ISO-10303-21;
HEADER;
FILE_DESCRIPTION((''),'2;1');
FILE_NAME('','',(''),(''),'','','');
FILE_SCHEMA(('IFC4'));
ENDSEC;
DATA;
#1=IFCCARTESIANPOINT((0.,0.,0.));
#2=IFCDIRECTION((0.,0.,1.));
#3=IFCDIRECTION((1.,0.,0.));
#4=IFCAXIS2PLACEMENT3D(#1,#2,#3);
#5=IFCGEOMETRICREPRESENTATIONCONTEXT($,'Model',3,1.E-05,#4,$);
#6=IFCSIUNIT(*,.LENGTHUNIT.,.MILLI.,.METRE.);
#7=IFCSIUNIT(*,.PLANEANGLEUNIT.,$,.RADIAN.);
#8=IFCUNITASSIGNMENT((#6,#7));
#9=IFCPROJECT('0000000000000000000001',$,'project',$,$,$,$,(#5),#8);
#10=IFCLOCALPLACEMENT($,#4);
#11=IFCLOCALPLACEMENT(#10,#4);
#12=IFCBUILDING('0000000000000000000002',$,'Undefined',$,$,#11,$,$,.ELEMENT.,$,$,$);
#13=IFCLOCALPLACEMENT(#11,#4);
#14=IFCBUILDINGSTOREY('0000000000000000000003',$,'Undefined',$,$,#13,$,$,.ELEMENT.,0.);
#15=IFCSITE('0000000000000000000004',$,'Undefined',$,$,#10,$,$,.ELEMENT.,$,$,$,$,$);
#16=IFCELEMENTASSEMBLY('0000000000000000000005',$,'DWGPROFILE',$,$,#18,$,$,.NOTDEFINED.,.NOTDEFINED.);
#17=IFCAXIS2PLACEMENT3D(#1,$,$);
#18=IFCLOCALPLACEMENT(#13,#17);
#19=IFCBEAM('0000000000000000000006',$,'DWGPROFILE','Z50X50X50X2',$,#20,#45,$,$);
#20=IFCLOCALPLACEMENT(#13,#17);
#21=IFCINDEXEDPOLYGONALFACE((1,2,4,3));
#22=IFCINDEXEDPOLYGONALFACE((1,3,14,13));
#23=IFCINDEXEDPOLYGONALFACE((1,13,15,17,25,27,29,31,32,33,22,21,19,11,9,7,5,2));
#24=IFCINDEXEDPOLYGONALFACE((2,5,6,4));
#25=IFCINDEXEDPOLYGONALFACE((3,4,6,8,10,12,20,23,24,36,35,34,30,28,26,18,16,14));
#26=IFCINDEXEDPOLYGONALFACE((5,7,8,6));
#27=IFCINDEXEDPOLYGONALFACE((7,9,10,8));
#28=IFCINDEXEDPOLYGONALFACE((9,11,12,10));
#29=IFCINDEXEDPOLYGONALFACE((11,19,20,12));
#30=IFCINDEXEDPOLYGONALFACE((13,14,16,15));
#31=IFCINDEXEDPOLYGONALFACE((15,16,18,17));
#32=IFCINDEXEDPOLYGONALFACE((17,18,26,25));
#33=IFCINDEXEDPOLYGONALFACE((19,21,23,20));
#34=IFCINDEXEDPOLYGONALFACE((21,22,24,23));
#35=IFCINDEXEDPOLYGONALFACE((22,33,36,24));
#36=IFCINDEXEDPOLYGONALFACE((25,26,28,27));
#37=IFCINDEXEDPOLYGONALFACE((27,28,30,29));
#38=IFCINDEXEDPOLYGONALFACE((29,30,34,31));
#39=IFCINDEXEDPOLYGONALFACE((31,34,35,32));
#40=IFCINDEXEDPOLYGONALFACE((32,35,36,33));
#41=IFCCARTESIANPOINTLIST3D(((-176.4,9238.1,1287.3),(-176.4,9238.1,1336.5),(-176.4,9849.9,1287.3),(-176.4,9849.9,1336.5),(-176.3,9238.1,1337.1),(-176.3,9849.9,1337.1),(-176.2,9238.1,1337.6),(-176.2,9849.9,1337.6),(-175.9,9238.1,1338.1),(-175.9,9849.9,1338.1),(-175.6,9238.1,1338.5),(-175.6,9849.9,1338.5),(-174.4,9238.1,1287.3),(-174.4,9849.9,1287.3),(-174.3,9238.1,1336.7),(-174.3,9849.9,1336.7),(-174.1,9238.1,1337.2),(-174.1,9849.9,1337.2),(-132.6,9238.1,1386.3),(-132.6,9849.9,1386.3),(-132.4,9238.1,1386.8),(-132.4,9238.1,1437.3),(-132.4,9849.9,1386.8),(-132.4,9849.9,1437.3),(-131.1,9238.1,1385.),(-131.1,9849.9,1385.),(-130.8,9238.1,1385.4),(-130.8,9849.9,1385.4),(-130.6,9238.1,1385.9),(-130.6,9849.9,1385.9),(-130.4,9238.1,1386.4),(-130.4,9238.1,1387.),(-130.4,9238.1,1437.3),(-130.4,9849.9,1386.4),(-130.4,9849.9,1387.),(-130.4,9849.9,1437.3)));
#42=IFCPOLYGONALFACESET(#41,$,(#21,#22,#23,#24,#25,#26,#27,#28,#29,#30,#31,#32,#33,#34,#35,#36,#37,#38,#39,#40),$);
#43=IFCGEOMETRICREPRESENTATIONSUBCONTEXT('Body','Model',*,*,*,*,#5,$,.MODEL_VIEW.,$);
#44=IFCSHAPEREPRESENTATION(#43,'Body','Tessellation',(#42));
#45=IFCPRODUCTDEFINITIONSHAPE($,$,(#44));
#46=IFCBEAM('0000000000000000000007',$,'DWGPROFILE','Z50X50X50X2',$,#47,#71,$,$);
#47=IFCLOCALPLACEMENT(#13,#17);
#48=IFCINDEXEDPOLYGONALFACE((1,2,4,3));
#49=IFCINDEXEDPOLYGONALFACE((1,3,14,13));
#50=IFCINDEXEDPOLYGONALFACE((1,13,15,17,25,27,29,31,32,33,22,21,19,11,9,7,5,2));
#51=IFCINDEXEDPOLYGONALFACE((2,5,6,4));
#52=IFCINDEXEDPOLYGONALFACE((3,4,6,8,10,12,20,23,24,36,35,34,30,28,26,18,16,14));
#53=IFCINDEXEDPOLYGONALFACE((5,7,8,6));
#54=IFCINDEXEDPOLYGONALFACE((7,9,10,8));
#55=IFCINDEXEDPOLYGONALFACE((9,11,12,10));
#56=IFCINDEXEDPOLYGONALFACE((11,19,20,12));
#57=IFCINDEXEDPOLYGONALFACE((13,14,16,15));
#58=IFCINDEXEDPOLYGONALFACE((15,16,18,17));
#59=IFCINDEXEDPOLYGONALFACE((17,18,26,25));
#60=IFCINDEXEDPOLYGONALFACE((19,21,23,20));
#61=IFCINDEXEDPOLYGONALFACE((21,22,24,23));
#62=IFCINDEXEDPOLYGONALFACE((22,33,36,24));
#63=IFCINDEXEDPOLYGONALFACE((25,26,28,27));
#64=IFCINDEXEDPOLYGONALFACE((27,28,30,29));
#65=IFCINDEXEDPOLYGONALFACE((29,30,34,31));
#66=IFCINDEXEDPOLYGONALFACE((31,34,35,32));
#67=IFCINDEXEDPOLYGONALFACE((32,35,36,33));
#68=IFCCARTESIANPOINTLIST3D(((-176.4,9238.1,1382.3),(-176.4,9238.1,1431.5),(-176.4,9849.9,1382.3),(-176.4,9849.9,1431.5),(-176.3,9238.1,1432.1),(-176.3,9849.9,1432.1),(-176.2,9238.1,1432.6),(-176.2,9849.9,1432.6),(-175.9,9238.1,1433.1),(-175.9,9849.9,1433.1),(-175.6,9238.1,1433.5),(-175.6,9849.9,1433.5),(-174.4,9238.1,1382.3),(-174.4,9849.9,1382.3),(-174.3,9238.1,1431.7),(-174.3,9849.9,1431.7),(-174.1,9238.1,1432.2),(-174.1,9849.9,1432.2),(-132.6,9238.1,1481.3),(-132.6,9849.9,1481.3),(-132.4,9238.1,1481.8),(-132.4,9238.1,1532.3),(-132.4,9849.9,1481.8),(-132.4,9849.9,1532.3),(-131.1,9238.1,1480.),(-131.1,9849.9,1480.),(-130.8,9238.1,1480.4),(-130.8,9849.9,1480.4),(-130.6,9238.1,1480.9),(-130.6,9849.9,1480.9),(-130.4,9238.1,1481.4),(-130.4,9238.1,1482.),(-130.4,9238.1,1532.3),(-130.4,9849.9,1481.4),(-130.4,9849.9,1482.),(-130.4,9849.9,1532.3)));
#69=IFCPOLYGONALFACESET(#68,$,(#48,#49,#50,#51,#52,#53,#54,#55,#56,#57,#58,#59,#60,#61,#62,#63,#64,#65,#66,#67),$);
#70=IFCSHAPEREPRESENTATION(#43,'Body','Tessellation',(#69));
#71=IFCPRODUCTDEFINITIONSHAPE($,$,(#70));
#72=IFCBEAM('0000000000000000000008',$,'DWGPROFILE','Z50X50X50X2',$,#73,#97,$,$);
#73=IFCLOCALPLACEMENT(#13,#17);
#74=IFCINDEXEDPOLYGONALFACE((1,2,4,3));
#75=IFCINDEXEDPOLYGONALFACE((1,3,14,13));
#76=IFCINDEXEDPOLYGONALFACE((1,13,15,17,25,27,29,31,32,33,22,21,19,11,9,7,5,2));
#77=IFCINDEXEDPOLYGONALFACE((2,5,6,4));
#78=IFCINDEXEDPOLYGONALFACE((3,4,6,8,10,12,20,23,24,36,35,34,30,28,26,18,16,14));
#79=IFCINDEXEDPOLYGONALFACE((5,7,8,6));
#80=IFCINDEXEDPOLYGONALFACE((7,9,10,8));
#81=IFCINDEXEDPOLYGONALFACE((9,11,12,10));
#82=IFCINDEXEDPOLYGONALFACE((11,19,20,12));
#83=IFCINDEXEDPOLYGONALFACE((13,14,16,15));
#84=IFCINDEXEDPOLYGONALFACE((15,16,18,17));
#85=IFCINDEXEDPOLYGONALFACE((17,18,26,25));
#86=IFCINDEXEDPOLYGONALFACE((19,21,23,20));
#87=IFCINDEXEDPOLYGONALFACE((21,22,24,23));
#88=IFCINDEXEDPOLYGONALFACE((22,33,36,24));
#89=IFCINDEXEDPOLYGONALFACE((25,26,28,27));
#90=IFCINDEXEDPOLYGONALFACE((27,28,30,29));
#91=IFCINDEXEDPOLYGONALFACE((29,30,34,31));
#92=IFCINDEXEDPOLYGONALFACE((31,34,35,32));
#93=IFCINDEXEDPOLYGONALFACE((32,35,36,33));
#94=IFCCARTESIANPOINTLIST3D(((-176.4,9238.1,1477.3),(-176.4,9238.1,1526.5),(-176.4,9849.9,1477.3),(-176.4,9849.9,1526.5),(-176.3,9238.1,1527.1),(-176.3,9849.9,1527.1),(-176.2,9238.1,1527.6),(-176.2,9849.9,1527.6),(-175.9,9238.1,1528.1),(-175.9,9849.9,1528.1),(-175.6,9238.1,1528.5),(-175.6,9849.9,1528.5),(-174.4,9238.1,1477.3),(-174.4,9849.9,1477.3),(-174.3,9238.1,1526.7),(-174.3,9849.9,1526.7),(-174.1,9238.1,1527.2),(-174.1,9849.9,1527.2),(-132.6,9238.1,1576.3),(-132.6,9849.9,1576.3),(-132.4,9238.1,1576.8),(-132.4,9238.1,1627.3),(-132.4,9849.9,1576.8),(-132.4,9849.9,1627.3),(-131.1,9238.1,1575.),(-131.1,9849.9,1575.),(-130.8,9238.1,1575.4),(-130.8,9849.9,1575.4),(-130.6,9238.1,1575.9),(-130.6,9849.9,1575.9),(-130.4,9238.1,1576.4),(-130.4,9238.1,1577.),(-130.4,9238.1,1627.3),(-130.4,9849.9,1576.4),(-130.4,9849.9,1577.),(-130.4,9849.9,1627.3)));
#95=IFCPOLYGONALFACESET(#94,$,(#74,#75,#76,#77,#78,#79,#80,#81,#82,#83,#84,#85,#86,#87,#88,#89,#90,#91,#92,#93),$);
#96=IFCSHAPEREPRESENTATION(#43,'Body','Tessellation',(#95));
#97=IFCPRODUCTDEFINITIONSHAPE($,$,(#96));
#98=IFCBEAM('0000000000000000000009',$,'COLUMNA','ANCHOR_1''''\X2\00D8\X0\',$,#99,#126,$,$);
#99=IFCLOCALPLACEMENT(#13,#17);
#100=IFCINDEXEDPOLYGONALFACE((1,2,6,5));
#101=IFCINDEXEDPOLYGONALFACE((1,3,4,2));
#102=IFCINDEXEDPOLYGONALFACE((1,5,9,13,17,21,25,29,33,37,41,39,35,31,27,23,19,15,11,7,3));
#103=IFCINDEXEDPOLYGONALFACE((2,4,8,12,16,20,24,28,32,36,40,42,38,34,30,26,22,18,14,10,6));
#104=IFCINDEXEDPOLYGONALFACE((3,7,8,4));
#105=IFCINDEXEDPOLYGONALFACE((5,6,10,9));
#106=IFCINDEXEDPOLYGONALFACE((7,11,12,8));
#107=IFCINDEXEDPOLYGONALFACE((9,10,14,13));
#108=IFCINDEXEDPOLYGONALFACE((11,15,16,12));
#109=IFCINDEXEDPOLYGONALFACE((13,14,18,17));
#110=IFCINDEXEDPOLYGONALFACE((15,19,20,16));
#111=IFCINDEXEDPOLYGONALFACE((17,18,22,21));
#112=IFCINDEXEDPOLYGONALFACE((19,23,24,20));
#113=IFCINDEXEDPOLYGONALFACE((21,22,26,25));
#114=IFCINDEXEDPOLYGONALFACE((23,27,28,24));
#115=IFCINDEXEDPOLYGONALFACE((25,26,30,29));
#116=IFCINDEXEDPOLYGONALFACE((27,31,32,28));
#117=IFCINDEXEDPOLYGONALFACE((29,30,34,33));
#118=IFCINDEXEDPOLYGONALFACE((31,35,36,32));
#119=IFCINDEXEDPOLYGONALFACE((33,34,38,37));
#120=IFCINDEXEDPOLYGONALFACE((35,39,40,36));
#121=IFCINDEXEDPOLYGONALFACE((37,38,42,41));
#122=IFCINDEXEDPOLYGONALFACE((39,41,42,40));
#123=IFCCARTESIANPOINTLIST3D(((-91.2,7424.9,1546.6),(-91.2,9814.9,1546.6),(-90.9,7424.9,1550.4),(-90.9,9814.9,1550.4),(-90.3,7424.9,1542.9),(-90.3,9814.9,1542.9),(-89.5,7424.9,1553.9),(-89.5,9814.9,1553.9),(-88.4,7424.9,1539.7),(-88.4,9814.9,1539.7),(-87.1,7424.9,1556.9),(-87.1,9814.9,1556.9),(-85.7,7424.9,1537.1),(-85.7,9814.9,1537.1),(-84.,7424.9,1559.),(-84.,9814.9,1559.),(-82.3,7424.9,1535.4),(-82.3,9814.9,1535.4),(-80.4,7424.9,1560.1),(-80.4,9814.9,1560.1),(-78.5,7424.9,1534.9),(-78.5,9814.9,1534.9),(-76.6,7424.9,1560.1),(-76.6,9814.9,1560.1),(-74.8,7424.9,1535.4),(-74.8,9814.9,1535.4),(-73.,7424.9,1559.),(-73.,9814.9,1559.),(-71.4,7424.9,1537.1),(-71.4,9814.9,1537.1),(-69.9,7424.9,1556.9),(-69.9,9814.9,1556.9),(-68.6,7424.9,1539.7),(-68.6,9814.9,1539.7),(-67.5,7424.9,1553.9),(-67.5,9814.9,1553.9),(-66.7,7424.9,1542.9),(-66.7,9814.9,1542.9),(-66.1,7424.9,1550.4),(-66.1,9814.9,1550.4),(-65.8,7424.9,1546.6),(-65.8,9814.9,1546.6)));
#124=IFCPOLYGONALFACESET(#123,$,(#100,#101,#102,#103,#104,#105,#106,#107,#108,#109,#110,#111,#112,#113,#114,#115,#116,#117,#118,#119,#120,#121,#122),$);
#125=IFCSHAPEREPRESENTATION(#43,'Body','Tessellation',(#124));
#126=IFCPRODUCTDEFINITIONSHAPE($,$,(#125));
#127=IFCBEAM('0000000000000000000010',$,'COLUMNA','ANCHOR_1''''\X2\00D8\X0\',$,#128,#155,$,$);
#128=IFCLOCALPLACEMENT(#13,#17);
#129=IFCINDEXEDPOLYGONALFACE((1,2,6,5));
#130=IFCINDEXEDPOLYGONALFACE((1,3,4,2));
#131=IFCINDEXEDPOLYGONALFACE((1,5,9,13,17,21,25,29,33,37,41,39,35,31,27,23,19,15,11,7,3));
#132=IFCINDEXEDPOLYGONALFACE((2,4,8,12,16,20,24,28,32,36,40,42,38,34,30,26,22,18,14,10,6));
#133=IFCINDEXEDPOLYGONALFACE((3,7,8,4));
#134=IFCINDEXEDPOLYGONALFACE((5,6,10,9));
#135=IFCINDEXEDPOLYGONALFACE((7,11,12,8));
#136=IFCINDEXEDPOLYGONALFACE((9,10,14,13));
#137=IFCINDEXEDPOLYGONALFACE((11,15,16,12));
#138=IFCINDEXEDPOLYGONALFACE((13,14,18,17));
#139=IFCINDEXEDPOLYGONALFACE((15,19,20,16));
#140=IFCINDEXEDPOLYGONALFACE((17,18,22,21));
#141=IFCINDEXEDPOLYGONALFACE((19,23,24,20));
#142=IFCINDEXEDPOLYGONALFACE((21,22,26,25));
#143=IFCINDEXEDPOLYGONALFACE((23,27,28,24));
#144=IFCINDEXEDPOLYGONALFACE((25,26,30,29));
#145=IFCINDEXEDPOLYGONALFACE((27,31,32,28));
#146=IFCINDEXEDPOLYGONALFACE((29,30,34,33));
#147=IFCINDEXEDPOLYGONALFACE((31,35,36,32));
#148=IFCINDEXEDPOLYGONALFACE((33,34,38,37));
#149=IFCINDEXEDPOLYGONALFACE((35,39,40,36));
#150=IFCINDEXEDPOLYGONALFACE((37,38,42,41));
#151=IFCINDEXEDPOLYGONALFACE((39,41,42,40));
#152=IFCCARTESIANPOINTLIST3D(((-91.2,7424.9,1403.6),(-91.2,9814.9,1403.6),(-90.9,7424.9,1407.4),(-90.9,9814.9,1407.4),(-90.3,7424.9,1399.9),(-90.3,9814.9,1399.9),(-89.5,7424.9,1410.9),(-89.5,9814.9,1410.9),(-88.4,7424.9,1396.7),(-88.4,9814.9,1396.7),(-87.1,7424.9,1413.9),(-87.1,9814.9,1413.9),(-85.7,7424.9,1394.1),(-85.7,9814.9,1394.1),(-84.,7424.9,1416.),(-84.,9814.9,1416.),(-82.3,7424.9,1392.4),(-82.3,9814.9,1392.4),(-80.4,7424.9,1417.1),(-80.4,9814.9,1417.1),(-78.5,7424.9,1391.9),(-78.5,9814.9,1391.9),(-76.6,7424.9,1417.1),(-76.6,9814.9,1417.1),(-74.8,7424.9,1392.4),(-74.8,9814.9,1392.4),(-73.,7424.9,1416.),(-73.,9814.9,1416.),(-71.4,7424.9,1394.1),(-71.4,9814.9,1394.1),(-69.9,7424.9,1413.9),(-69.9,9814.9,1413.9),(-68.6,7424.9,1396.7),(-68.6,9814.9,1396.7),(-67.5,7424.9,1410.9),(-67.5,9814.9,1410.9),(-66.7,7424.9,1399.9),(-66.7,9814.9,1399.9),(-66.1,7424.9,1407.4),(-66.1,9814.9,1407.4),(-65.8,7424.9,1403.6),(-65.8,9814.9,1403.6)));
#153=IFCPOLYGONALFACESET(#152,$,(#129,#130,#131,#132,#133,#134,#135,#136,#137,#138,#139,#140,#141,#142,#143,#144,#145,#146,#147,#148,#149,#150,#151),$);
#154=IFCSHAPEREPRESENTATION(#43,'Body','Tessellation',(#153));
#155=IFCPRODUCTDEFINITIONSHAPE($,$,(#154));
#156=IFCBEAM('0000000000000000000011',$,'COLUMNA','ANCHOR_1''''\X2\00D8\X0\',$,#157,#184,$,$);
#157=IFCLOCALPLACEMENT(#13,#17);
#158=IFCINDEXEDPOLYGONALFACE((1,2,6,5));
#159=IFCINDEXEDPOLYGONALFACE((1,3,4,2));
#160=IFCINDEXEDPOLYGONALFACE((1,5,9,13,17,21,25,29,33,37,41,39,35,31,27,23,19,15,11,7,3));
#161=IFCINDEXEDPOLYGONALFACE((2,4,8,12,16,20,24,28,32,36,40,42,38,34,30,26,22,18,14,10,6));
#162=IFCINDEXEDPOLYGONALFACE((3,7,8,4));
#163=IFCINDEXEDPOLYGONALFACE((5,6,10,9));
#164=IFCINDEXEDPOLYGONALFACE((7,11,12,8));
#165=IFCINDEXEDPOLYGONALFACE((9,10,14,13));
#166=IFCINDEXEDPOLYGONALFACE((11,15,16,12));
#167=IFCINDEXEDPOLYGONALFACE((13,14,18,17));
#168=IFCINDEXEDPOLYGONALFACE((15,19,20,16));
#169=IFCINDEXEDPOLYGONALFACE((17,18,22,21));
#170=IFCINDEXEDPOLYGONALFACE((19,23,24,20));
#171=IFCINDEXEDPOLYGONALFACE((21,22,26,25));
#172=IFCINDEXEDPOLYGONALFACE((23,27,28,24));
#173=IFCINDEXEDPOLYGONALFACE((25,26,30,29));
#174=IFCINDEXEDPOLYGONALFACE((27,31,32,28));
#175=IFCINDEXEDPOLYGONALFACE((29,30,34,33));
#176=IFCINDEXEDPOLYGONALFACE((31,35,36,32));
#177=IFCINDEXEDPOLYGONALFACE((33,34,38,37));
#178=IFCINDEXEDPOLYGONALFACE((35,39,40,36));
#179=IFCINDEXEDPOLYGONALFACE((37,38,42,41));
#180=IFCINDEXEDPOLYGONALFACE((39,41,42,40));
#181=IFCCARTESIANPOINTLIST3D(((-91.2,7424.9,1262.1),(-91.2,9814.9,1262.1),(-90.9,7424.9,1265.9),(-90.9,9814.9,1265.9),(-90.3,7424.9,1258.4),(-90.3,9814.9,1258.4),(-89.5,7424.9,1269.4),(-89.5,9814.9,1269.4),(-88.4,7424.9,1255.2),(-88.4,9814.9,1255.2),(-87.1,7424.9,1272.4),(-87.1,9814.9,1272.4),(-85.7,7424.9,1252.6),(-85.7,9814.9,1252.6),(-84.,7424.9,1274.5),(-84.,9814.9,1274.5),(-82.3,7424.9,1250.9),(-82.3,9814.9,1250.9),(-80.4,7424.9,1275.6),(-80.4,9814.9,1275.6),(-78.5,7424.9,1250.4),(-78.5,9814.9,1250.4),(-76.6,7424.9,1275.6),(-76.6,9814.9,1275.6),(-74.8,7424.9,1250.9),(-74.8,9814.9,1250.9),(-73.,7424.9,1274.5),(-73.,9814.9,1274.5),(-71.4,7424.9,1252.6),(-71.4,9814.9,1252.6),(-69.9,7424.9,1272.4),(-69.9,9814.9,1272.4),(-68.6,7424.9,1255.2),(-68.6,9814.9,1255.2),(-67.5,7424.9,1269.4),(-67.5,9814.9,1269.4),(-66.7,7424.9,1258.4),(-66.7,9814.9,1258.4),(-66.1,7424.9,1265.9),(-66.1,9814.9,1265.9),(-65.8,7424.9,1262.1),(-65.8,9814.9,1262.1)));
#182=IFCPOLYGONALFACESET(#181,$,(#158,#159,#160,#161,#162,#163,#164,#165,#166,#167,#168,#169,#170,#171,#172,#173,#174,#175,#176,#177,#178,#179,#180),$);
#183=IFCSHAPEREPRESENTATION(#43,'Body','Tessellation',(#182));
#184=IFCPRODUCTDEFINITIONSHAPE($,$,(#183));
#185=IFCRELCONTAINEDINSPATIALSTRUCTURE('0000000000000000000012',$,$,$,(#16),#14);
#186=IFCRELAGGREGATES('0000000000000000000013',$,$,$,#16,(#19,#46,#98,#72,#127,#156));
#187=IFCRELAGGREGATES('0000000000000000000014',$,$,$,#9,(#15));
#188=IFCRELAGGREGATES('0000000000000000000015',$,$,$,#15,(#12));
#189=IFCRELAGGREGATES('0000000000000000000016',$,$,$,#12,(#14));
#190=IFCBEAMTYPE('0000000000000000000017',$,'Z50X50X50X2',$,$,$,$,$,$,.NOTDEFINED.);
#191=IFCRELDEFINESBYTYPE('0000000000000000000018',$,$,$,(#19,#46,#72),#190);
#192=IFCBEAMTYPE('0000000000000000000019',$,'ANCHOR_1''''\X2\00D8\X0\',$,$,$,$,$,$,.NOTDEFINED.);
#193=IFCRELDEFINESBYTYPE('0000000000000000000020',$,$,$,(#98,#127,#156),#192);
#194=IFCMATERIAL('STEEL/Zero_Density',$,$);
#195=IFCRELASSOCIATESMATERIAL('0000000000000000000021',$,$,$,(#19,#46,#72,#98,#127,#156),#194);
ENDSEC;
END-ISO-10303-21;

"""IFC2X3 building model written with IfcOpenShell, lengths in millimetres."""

from ifc_helpers import new_model, si_unit, frame, origin_with_axes, origin_2d_with_axis, place, context, subcontext, project, spatial, polyline, circle, outline, extrude, material, type_object, element, aggregate, save


model = new_model("IFC2X3")

# Units and contexts
model_context = context("Model", 3, precision=1e-05, world=origin_with_axes())
body_context = subcontext(model_context, "Body", "Model", "MODEL_VIEW")
ifc_project = project(units=[si_unit("LENGTHUNIT", "METRE", prefix="MILLI"), si_unit("PLANEANGLEUNIT", "RADIAN")], contexts=[model_context])

# Site, building, storey
site_placement = place(None, origin_with_axes())
site = spatial("IfcSite", under=ifc_project, at=site_placement, Name="Undefined", CompositionType="ELEMENT")
building_placement = place(site_placement, origin_with_axes())
building = spatial("IfcBuilding", under=site, at=building_placement, Name="Undefined", CompositionType="ELEMENT")
storey_placement = place(building_placement, origin_with_axes())
storey = spatial("IfcBuildingStorey", under=building, at=storey_placement, Name="Undefined", CompositionType="ELEMENT", Elevation=0.0)

# Shared definitions
ifc_material_1 = material(Name="STEEL/Zero_Density")
beam_type_1 = type_object("IfcBeamType", Name="Z50X50X50X2", PredefinedType="NOTDEFINED")

# Element assembly, beams
assembly_1_placement = place(storey_placement, origin_with_axes())
assembly_1 = element("IfcElementAssembly", 1, at=assembly_1_placement, inside=storey, Name="DWGPROFILE", AssemblyPlace="NOTDEFINED", PredefinedType="NOTDEFINED")
beam_1_placement = place(assembly_1_placement, frame((-153.4, 9849.9, 1362.3), z_axis=(0.0, 0.0, 1.0), x_axis=(0.0, -1.0, 0.0)))
beam_1 = element("IfcBeam", 2, at=beam_1_placement, type_object=beam_type_1, material=ifc_material_1, Name="DWGPROFILE", Description="Z50X50X50X2", context=body_context, shape_type="SweptSolid", body=[
    extrude(outline(polyline([(-22.9, 24.1), (-23.0, 24.7), (-23.0, 75.0), (-21.0, 75.0), (-21.0, 24.5), (-20.7, 24.0), (22.2, -23.8), (22.6, -24.2), (22.8, -24.7), (22.9, -25.2), (23.0, -25.8), (23.0, -75.0), (21.0, -75.0), (21.0, -25.6), (20.7, -25.1), (-22.2, 22.6), (-22.6, 23.1), (-22.8, 23.6), (-22.9, 24.1)])), frame((611.8, 0.0, 0.0), z_axis=(-1.0, 0.0, 0.0), x_axis=(0.0, -1.0, 0.0)), (0.0, 0.0, 1.0), 611.8),
])
beam_2_placement = place(assembly_1_placement, frame((-153.4, 9849.9, 1457.3), z_axis=(0.0, 0.0, 1.0), x_axis=(0.0, -1.0, 0.0)))
beam_2 = element("IfcBeam", 3, at=beam_2_placement, type_object=beam_type_1, material=ifc_material_1, Name="DWGPROFILE", Description="Z50X50X50X2", context=body_context, shape_type="SweptSolid", body=[
    extrude(outline(polyline([(-22.9, 24.1), (-23.0, 24.7), (-23.0, 75.0), (-21.0, 75.0), (-21.0, 24.5), (-20.7, 24.0), (22.2, -23.8), (22.6, -24.2), (22.8, -24.7), (22.9, -25.2), (23.0, -25.8), (23.0, -75.0), (21.0, -75.0), (21.0, -25.6), (20.7, -25.1), (-22.2, 22.6), (-22.6, 23.1), (-22.8, 23.6), (-22.9, 24.1)])), frame((611.8, 0.0, 0.0), z_axis=(-1.0, 0.0, 0.0), x_axis=(0.0, -1.0, 0.0)), (0.0, 0.0, 1.0), 611.8),
])
beam_3_placement = place(assembly_1_placement, frame((-153.4, 9849.9, 1552.3), z_axis=(0.0, 0.0, 1.0), x_axis=(0.0, -1.0, 0.0)))
beam_3 = element("IfcBeam", 4, at=beam_3_placement, type_object=beam_type_1, material=ifc_material_1, Name="DWGPROFILE", Description="Z50X50X50X2", context=body_context, shape_type="SweptSolid", body=[
    extrude(outline(polyline([(-22.9, 24.1), (-23.0, 24.7), (-23.0, 75.0), (-21.0, 75.0), (-21.0, 24.5), (-20.7, 24.0), (22.2, -23.8), (22.6, -24.2), (22.8, -24.7), (22.9, -25.2), (23.0, -25.8), (23.0, -75.0), (21.0, -75.0), (21.0, -25.6), (20.7, -25.1), (-22.2, 22.6), (-22.6, 23.1), (-22.8, 23.6), (-22.9, 24.1)])), frame((611.8, 0.0, 0.0), z_axis=(-1.0, 0.0, 0.0), x_axis=(0.0, -1.0, 0.0)), (0.0, 0.0, 1.0), 611.8),
])
beam_type_2 = type_object("IfcBeamType", Name="ANCHOR_1''Ø", PredefinedType="NOTDEFINED")
beam_4_placement = place(assembly_1_placement, frame((-78.5, 9814.9, 1547.6), z_axis=(-1.0, 0.0, 0.0), x_axis=(0.0, -1.0, 0.0)))
beam_4 = element("IfcBeam", 5, at=beam_4_placement, type_object=beam_type_2, material=ifc_material_1, Name="COLUMNA", Description="ANCHOR_1''Ø", context=body_context, shape_type="SweptSolid", body=[
    extrude(circle(Radius=12.7, at=origin_2d_with_axis()), frame((2390.0, 0.0, 0.0), z_axis=(-1.0, 0.0, 0.0), x_axis=(0.0, -1.0, 0.0)), (0.0, 0.0, 1.0), 2390.0),
])
beam_5_placement = place(assembly_1_placement, frame((-78.5, 9814.9, 1404.6), z_axis=(-1.0, 0.0, 0.0), x_axis=(0.0, -1.0, 0.0)))
beam_5 = element("IfcBeam", 6, at=beam_5_placement, type_object=beam_type_2, material=ifc_material_1, Name="COLUMNA", Description="ANCHOR_1''Ø", context=body_context, shape_type="SweptSolid", body=[
    extrude(circle(Radius=12.7, at=origin_2d_with_axis()), frame((2390.0, 0.0, 0.0), z_axis=(-1.0, 0.0, 0.0), x_axis=(0.0, -1.0, 0.0)), (0.0, 0.0, 1.0), 2390.0),
])
beam_6_placement = place(assembly_1_placement, frame((-78.5, 9814.9, 1263.1), z_axis=(-1.0, 0.0, 0.0), x_axis=(0.0, -1.0, 0.0)))
beam_6 = element("IfcBeam", 7, at=beam_6_placement, type_object=beam_type_2, material=ifc_material_1, Name="COLUMNA", Description="ANCHOR_1''Ø", context=body_context, shape_type="SweptSolid", body=[
    extrude(circle(Radius=12.7, at=origin_2d_with_axis()), frame((2390.0, 0.0, 0.0), z_axis=(-1.0, 0.0, 0.0), x_axis=(0.0, -1.0, 0.0)), (0.0, 0.0, 1.0), 2390.0),
])

aggregate(assembly_1, [beam_1, beam_2, beam_4, beam_3, beam_5, beam_6])

save(model, "model.ifc")
